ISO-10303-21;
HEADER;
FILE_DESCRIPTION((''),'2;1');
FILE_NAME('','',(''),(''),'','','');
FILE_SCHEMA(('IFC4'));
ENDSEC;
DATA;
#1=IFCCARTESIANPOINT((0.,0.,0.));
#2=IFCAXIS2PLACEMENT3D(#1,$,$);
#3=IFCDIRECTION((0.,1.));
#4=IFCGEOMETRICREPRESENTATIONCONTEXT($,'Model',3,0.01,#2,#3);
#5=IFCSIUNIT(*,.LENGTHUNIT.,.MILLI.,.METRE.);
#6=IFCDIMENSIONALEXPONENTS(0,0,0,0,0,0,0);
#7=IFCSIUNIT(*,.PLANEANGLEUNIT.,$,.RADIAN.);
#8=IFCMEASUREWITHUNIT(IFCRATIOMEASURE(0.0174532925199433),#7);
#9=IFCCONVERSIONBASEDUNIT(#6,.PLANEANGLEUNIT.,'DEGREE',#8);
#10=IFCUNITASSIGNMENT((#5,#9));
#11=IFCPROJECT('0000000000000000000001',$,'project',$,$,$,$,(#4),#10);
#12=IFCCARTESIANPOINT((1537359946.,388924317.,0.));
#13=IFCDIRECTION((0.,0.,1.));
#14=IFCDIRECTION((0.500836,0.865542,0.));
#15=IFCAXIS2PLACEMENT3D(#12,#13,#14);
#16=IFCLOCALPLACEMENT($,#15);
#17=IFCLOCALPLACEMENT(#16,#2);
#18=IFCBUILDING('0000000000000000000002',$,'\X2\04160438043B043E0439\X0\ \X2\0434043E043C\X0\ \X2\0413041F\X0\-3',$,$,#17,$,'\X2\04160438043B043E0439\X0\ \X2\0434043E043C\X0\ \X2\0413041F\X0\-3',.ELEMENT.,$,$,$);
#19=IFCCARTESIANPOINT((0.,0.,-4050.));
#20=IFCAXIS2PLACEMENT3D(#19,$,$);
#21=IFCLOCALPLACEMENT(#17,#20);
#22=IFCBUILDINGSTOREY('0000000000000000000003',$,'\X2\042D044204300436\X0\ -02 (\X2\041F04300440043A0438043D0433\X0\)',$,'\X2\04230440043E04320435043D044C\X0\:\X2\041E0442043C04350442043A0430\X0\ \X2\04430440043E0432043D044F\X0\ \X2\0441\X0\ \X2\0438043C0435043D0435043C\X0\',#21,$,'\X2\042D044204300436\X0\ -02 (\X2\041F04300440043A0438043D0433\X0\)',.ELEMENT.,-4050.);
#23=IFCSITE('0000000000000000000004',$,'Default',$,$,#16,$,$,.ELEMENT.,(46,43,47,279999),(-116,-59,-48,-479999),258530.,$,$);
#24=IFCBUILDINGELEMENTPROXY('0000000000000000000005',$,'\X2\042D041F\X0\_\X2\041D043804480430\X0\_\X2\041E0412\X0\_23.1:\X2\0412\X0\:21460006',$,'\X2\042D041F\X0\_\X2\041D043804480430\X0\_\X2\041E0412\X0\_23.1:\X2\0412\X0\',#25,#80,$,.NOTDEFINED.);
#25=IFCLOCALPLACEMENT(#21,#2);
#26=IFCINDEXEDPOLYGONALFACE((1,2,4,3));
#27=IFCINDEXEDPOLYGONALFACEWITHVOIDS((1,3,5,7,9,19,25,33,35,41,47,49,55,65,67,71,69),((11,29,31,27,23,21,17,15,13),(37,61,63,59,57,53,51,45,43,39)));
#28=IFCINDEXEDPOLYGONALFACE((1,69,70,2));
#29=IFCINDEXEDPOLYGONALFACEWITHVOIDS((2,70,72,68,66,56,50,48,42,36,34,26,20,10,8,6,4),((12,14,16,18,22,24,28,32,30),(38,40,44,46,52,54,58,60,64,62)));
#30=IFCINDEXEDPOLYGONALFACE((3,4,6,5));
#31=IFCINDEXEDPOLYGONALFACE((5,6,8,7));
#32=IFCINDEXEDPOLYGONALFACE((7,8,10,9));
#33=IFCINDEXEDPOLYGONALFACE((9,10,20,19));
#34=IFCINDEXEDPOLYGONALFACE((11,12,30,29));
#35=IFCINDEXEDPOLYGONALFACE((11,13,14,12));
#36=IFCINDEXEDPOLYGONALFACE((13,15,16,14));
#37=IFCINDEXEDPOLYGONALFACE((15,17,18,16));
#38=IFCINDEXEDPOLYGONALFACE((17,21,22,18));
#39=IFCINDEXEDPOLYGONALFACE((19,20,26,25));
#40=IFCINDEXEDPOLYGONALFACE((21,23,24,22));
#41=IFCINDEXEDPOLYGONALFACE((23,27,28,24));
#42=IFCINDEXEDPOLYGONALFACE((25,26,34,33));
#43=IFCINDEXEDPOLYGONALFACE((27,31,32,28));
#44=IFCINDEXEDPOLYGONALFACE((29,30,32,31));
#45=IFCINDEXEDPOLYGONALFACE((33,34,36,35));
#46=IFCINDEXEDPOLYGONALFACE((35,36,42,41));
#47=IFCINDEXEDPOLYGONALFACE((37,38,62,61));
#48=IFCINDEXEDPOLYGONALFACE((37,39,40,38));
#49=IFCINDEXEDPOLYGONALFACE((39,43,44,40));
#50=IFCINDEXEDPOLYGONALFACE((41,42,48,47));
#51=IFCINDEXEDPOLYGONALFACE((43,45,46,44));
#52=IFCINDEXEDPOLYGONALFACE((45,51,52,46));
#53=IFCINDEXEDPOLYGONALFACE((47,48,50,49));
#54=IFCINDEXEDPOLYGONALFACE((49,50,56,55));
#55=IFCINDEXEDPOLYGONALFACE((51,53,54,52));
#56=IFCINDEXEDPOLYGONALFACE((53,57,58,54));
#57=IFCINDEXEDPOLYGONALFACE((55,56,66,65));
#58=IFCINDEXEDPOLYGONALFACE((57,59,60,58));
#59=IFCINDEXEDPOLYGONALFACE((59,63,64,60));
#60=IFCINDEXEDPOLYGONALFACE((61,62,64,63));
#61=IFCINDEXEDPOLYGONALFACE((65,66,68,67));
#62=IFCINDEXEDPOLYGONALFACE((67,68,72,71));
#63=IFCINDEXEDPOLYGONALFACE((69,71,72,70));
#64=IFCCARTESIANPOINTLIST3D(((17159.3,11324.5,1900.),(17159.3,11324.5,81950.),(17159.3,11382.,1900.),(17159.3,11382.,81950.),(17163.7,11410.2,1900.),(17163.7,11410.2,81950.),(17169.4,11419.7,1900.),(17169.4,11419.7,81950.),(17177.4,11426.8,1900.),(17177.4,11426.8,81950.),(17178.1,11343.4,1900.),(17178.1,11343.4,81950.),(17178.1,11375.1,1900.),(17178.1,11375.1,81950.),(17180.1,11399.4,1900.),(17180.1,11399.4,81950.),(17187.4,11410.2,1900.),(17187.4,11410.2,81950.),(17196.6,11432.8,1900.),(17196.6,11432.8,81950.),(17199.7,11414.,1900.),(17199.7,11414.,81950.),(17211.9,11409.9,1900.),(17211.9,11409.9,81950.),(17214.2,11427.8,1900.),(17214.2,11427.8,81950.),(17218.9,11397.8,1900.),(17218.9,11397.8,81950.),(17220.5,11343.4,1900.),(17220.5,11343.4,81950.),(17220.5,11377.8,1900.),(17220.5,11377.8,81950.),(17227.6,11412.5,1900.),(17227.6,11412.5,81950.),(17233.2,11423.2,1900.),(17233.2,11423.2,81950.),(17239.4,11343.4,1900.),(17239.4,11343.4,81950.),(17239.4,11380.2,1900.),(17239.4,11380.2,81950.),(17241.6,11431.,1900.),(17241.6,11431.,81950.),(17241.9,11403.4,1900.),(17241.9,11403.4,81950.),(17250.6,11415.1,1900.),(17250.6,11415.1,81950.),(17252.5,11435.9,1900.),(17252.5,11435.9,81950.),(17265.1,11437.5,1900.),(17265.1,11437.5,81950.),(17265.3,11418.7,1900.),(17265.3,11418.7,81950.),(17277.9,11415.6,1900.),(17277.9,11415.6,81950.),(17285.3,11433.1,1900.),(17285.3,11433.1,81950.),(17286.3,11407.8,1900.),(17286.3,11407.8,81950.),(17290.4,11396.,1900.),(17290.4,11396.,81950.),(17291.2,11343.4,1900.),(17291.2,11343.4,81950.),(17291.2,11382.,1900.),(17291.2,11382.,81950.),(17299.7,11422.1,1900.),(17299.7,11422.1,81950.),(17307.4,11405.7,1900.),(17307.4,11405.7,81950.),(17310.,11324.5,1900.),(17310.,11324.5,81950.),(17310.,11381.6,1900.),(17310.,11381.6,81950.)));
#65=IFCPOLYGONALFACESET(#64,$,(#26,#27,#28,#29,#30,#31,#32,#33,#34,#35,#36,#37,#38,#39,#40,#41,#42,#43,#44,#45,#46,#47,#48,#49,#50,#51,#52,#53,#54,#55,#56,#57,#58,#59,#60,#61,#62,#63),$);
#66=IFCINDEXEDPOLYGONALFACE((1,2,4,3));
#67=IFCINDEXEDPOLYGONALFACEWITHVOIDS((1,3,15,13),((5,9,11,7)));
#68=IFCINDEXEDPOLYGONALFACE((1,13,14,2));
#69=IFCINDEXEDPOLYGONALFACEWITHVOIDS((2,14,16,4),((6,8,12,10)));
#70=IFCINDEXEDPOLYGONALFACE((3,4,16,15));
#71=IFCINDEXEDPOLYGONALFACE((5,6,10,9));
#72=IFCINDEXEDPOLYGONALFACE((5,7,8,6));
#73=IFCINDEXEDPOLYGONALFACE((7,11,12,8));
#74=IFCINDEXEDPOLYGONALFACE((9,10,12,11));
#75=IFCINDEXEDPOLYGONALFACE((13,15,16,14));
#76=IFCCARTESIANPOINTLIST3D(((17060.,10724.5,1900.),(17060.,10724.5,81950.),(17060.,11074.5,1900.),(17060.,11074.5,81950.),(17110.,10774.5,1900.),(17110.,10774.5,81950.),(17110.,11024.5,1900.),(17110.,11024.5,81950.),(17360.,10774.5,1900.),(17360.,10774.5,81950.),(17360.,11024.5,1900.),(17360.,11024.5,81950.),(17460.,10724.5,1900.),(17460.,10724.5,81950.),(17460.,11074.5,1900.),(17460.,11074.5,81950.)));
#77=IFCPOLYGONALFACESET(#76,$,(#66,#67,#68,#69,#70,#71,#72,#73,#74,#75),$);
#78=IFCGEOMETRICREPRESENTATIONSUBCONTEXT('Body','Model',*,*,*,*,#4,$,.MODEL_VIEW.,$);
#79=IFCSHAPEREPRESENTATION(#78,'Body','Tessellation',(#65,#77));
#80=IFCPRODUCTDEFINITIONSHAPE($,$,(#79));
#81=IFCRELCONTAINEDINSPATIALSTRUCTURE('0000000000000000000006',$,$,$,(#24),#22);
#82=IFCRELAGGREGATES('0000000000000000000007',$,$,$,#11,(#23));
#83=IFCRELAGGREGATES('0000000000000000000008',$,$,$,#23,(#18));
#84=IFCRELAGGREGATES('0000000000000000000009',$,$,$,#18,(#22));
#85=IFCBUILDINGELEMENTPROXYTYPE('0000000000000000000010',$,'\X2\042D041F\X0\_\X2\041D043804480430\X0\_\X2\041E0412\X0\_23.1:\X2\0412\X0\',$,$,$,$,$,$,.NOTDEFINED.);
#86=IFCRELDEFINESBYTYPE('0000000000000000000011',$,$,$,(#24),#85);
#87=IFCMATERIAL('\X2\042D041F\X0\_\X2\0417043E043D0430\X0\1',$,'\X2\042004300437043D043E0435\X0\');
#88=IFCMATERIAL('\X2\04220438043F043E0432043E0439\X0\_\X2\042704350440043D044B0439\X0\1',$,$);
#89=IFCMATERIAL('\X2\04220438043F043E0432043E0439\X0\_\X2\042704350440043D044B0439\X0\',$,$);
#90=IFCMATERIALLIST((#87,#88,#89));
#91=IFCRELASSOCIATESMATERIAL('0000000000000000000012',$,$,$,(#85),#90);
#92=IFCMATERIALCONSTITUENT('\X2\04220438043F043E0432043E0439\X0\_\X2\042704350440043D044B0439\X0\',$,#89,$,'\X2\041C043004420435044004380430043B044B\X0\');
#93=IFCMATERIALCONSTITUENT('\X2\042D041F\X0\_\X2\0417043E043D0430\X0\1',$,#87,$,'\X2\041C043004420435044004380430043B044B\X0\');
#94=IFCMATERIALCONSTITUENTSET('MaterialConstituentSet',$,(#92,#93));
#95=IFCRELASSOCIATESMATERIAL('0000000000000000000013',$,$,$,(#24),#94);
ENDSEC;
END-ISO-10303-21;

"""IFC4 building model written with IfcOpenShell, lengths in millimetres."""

from ifc_helpers import new_model, entity, si_unit, converted_unit, direction, frame, origin, place, context, subcontext, project, spatial, polyline, outline, extrude, source, transform, mapped, material, material_list, constituent, constituent_set, type_object, type_shapes, element, save


model = new_model("IFC4")

# Units and contexts
model_context = context("Model", 3, precision=0.01, world=origin(), true_north=direction((0.0, 1.0)))
body_context = subcontext(model_context, "Body", "Model", "MODEL_VIEW")
ifc_project = project(units=[si_unit("LENGTHUNIT", "METRE", prefix="MILLI"), converted_unit("PLANEANGLEUNIT", "DEGREE", entity("IfcRatioMeasure", 0.0174532925199433), si_unit("PLANEANGLEUNIT", "RADIAN"), dimensions=[0, 0, 0, 0, 0, 0, 0])], contexts=[model_context])

# Site, building, storey
site_placement = place(None, frame((1537359946.0, 388924317.0, 0.0), z_axis=(0.0, 0.0, 1.0), x_axis=(0.500836, 0.865542, 0.0)))
site = spatial("IfcSite", under=ifc_project, at=site_placement, Name="Default", CompositionType="ELEMENT", RefLatitude=(46, 43, 47, 279999), RefLongitude=(-116, -59, -48, -479999), RefElevation=258530.0)
building_placement = place(site_placement, origin())
building = spatial("IfcBuilding", under=site, at=building_placement, Name="Жилой дом ГП-3", LongName="Жилой дом ГП-3", CompositionType="ELEMENT")
storey_placement = place(building_placement, frame((0.0, 0.0, -4050.0)))
storey = spatial("IfcBuildingStorey", under=building, at=storey_placement, Name="Этаж -02 (Паркинг)", ObjectType="Уровень:Отметка уровня с именем", LongName="Этаж -02 (Паркинг)", CompositionType="ELEMENT", Elevation=-4050.0)

# Building element proxy
ifc_material_1 = material(Name="Типовой_Черный")
ifc_material_2 = material(Name="ЭП_Зона1", Category="Разное")
ifc_material_3 = material(Name="Типовой_Черный1")
ifc_constituent_1 = constituent(ifc_material_1, Name="Типовой_Черный", Category="Материалы")
ifc_constituent_2 = constituent(ifc_material_2, Name="ЭП_Зона1", Category="Материалы")
ifc_constituent_set_1 = constituent_set(constituents=[ifc_constituent_1, ifc_constituent_2], Name="MaterialConstituentSet")
ifc_material_list_1 = material_list([ifc_material_2, ifc_material_3, ifc_material_1])
building_element_proxy_type_1 = type_object("IfcBuildingElementProxyType", Name="ЭП_Ниша_ОВ_23.1:В", PredefinedType="NOTDEFINED", material=ifc_material_list_1)
shared_shape_1 = source(origin(), body_context, "Body", "SweptSolid", [
    extrude(outline(polyline([(-83.2, -76.3), (-26.1, -76.3), (-2.0, -73.7), (14.4, -66.1), (25.4, -51.7), (29.8, -31.4), (28.2, -18.8), (23.3, -8.0), (15.5, 0.5), (4.8, 6.1), (20.1, 19.4), (25.1, 37.0), (19.1, 56.3), (11.9, 64.3), (2.5, 69.9), (-25.7, 74.4), (-83.2, 74.4), (-83.2, -76.3)]), holes=[polyline([(-64.3, 13.1), (-64.3, 55.5), (-32.6, 55.5), (-8.4, 53.6), (2.5, 46.3), (6.3, 34.0), (2.2, 21.7), (-9.9, 14.8), (-29.9, 13.1), (-64.3, 13.1)]), polyline([(-64.3, -57.5), (-64.3, -5.7), (-27.6, -5.7), (-4.3, -8.2), (7.4, -16.9), (11.0, -31.6), (7.9, -44.3), (0.1, -52.7), (-11.7, -56.8), (-25.7, -57.5), (-64.3, -57.5)])]), frame((683.2, 226.3, 0.0)), (0.0, 0.0, 1.0), 80050.0),
    extrude(outline(polyline([(-175.0, -200.0), (175.0, -200.0), (175.0, 200.0), (-175.0, 200.0), (-175.0, -200.0)]), holes=[polyline([(125.0, 150.0), (125.0, -100.0), (-125.0, -100.0), (-125.0, 150.0), (125.0, 150.0)])]), frame((175.0, 200.0, 0.0)), (0.0, 0.0, 1.0), 80050.0),
])
type_shapes(building_element_proxy_type_1, [shared_shape_1])
proxy_1_placement = place(storey_placement, frame((17460.0, 10724.5, 1900.0), z_axis=(0.0, 0.0, 1.0), x_axis=(0.0, 1.0, 0.0)))
element("IfcBuildingElementProxy", 1, at=proxy_1_placement, inside=storey, type_object=building_element_proxy_type_1, material=ifc_constituent_set_1, Name="ЭП_Ниша_ОВ_23.1:В:21460006", ObjectType="ЭП_Ниша_ОВ_23.1:В", PredefinedType="NOTDEFINED", context=body_context, shape_type="MappedRepresentation", body=[
    mapped(shared_shape_1, transform((0.0, 0.0, 0.0), scale=1.0)),
])

save(model, "model.ifc")
